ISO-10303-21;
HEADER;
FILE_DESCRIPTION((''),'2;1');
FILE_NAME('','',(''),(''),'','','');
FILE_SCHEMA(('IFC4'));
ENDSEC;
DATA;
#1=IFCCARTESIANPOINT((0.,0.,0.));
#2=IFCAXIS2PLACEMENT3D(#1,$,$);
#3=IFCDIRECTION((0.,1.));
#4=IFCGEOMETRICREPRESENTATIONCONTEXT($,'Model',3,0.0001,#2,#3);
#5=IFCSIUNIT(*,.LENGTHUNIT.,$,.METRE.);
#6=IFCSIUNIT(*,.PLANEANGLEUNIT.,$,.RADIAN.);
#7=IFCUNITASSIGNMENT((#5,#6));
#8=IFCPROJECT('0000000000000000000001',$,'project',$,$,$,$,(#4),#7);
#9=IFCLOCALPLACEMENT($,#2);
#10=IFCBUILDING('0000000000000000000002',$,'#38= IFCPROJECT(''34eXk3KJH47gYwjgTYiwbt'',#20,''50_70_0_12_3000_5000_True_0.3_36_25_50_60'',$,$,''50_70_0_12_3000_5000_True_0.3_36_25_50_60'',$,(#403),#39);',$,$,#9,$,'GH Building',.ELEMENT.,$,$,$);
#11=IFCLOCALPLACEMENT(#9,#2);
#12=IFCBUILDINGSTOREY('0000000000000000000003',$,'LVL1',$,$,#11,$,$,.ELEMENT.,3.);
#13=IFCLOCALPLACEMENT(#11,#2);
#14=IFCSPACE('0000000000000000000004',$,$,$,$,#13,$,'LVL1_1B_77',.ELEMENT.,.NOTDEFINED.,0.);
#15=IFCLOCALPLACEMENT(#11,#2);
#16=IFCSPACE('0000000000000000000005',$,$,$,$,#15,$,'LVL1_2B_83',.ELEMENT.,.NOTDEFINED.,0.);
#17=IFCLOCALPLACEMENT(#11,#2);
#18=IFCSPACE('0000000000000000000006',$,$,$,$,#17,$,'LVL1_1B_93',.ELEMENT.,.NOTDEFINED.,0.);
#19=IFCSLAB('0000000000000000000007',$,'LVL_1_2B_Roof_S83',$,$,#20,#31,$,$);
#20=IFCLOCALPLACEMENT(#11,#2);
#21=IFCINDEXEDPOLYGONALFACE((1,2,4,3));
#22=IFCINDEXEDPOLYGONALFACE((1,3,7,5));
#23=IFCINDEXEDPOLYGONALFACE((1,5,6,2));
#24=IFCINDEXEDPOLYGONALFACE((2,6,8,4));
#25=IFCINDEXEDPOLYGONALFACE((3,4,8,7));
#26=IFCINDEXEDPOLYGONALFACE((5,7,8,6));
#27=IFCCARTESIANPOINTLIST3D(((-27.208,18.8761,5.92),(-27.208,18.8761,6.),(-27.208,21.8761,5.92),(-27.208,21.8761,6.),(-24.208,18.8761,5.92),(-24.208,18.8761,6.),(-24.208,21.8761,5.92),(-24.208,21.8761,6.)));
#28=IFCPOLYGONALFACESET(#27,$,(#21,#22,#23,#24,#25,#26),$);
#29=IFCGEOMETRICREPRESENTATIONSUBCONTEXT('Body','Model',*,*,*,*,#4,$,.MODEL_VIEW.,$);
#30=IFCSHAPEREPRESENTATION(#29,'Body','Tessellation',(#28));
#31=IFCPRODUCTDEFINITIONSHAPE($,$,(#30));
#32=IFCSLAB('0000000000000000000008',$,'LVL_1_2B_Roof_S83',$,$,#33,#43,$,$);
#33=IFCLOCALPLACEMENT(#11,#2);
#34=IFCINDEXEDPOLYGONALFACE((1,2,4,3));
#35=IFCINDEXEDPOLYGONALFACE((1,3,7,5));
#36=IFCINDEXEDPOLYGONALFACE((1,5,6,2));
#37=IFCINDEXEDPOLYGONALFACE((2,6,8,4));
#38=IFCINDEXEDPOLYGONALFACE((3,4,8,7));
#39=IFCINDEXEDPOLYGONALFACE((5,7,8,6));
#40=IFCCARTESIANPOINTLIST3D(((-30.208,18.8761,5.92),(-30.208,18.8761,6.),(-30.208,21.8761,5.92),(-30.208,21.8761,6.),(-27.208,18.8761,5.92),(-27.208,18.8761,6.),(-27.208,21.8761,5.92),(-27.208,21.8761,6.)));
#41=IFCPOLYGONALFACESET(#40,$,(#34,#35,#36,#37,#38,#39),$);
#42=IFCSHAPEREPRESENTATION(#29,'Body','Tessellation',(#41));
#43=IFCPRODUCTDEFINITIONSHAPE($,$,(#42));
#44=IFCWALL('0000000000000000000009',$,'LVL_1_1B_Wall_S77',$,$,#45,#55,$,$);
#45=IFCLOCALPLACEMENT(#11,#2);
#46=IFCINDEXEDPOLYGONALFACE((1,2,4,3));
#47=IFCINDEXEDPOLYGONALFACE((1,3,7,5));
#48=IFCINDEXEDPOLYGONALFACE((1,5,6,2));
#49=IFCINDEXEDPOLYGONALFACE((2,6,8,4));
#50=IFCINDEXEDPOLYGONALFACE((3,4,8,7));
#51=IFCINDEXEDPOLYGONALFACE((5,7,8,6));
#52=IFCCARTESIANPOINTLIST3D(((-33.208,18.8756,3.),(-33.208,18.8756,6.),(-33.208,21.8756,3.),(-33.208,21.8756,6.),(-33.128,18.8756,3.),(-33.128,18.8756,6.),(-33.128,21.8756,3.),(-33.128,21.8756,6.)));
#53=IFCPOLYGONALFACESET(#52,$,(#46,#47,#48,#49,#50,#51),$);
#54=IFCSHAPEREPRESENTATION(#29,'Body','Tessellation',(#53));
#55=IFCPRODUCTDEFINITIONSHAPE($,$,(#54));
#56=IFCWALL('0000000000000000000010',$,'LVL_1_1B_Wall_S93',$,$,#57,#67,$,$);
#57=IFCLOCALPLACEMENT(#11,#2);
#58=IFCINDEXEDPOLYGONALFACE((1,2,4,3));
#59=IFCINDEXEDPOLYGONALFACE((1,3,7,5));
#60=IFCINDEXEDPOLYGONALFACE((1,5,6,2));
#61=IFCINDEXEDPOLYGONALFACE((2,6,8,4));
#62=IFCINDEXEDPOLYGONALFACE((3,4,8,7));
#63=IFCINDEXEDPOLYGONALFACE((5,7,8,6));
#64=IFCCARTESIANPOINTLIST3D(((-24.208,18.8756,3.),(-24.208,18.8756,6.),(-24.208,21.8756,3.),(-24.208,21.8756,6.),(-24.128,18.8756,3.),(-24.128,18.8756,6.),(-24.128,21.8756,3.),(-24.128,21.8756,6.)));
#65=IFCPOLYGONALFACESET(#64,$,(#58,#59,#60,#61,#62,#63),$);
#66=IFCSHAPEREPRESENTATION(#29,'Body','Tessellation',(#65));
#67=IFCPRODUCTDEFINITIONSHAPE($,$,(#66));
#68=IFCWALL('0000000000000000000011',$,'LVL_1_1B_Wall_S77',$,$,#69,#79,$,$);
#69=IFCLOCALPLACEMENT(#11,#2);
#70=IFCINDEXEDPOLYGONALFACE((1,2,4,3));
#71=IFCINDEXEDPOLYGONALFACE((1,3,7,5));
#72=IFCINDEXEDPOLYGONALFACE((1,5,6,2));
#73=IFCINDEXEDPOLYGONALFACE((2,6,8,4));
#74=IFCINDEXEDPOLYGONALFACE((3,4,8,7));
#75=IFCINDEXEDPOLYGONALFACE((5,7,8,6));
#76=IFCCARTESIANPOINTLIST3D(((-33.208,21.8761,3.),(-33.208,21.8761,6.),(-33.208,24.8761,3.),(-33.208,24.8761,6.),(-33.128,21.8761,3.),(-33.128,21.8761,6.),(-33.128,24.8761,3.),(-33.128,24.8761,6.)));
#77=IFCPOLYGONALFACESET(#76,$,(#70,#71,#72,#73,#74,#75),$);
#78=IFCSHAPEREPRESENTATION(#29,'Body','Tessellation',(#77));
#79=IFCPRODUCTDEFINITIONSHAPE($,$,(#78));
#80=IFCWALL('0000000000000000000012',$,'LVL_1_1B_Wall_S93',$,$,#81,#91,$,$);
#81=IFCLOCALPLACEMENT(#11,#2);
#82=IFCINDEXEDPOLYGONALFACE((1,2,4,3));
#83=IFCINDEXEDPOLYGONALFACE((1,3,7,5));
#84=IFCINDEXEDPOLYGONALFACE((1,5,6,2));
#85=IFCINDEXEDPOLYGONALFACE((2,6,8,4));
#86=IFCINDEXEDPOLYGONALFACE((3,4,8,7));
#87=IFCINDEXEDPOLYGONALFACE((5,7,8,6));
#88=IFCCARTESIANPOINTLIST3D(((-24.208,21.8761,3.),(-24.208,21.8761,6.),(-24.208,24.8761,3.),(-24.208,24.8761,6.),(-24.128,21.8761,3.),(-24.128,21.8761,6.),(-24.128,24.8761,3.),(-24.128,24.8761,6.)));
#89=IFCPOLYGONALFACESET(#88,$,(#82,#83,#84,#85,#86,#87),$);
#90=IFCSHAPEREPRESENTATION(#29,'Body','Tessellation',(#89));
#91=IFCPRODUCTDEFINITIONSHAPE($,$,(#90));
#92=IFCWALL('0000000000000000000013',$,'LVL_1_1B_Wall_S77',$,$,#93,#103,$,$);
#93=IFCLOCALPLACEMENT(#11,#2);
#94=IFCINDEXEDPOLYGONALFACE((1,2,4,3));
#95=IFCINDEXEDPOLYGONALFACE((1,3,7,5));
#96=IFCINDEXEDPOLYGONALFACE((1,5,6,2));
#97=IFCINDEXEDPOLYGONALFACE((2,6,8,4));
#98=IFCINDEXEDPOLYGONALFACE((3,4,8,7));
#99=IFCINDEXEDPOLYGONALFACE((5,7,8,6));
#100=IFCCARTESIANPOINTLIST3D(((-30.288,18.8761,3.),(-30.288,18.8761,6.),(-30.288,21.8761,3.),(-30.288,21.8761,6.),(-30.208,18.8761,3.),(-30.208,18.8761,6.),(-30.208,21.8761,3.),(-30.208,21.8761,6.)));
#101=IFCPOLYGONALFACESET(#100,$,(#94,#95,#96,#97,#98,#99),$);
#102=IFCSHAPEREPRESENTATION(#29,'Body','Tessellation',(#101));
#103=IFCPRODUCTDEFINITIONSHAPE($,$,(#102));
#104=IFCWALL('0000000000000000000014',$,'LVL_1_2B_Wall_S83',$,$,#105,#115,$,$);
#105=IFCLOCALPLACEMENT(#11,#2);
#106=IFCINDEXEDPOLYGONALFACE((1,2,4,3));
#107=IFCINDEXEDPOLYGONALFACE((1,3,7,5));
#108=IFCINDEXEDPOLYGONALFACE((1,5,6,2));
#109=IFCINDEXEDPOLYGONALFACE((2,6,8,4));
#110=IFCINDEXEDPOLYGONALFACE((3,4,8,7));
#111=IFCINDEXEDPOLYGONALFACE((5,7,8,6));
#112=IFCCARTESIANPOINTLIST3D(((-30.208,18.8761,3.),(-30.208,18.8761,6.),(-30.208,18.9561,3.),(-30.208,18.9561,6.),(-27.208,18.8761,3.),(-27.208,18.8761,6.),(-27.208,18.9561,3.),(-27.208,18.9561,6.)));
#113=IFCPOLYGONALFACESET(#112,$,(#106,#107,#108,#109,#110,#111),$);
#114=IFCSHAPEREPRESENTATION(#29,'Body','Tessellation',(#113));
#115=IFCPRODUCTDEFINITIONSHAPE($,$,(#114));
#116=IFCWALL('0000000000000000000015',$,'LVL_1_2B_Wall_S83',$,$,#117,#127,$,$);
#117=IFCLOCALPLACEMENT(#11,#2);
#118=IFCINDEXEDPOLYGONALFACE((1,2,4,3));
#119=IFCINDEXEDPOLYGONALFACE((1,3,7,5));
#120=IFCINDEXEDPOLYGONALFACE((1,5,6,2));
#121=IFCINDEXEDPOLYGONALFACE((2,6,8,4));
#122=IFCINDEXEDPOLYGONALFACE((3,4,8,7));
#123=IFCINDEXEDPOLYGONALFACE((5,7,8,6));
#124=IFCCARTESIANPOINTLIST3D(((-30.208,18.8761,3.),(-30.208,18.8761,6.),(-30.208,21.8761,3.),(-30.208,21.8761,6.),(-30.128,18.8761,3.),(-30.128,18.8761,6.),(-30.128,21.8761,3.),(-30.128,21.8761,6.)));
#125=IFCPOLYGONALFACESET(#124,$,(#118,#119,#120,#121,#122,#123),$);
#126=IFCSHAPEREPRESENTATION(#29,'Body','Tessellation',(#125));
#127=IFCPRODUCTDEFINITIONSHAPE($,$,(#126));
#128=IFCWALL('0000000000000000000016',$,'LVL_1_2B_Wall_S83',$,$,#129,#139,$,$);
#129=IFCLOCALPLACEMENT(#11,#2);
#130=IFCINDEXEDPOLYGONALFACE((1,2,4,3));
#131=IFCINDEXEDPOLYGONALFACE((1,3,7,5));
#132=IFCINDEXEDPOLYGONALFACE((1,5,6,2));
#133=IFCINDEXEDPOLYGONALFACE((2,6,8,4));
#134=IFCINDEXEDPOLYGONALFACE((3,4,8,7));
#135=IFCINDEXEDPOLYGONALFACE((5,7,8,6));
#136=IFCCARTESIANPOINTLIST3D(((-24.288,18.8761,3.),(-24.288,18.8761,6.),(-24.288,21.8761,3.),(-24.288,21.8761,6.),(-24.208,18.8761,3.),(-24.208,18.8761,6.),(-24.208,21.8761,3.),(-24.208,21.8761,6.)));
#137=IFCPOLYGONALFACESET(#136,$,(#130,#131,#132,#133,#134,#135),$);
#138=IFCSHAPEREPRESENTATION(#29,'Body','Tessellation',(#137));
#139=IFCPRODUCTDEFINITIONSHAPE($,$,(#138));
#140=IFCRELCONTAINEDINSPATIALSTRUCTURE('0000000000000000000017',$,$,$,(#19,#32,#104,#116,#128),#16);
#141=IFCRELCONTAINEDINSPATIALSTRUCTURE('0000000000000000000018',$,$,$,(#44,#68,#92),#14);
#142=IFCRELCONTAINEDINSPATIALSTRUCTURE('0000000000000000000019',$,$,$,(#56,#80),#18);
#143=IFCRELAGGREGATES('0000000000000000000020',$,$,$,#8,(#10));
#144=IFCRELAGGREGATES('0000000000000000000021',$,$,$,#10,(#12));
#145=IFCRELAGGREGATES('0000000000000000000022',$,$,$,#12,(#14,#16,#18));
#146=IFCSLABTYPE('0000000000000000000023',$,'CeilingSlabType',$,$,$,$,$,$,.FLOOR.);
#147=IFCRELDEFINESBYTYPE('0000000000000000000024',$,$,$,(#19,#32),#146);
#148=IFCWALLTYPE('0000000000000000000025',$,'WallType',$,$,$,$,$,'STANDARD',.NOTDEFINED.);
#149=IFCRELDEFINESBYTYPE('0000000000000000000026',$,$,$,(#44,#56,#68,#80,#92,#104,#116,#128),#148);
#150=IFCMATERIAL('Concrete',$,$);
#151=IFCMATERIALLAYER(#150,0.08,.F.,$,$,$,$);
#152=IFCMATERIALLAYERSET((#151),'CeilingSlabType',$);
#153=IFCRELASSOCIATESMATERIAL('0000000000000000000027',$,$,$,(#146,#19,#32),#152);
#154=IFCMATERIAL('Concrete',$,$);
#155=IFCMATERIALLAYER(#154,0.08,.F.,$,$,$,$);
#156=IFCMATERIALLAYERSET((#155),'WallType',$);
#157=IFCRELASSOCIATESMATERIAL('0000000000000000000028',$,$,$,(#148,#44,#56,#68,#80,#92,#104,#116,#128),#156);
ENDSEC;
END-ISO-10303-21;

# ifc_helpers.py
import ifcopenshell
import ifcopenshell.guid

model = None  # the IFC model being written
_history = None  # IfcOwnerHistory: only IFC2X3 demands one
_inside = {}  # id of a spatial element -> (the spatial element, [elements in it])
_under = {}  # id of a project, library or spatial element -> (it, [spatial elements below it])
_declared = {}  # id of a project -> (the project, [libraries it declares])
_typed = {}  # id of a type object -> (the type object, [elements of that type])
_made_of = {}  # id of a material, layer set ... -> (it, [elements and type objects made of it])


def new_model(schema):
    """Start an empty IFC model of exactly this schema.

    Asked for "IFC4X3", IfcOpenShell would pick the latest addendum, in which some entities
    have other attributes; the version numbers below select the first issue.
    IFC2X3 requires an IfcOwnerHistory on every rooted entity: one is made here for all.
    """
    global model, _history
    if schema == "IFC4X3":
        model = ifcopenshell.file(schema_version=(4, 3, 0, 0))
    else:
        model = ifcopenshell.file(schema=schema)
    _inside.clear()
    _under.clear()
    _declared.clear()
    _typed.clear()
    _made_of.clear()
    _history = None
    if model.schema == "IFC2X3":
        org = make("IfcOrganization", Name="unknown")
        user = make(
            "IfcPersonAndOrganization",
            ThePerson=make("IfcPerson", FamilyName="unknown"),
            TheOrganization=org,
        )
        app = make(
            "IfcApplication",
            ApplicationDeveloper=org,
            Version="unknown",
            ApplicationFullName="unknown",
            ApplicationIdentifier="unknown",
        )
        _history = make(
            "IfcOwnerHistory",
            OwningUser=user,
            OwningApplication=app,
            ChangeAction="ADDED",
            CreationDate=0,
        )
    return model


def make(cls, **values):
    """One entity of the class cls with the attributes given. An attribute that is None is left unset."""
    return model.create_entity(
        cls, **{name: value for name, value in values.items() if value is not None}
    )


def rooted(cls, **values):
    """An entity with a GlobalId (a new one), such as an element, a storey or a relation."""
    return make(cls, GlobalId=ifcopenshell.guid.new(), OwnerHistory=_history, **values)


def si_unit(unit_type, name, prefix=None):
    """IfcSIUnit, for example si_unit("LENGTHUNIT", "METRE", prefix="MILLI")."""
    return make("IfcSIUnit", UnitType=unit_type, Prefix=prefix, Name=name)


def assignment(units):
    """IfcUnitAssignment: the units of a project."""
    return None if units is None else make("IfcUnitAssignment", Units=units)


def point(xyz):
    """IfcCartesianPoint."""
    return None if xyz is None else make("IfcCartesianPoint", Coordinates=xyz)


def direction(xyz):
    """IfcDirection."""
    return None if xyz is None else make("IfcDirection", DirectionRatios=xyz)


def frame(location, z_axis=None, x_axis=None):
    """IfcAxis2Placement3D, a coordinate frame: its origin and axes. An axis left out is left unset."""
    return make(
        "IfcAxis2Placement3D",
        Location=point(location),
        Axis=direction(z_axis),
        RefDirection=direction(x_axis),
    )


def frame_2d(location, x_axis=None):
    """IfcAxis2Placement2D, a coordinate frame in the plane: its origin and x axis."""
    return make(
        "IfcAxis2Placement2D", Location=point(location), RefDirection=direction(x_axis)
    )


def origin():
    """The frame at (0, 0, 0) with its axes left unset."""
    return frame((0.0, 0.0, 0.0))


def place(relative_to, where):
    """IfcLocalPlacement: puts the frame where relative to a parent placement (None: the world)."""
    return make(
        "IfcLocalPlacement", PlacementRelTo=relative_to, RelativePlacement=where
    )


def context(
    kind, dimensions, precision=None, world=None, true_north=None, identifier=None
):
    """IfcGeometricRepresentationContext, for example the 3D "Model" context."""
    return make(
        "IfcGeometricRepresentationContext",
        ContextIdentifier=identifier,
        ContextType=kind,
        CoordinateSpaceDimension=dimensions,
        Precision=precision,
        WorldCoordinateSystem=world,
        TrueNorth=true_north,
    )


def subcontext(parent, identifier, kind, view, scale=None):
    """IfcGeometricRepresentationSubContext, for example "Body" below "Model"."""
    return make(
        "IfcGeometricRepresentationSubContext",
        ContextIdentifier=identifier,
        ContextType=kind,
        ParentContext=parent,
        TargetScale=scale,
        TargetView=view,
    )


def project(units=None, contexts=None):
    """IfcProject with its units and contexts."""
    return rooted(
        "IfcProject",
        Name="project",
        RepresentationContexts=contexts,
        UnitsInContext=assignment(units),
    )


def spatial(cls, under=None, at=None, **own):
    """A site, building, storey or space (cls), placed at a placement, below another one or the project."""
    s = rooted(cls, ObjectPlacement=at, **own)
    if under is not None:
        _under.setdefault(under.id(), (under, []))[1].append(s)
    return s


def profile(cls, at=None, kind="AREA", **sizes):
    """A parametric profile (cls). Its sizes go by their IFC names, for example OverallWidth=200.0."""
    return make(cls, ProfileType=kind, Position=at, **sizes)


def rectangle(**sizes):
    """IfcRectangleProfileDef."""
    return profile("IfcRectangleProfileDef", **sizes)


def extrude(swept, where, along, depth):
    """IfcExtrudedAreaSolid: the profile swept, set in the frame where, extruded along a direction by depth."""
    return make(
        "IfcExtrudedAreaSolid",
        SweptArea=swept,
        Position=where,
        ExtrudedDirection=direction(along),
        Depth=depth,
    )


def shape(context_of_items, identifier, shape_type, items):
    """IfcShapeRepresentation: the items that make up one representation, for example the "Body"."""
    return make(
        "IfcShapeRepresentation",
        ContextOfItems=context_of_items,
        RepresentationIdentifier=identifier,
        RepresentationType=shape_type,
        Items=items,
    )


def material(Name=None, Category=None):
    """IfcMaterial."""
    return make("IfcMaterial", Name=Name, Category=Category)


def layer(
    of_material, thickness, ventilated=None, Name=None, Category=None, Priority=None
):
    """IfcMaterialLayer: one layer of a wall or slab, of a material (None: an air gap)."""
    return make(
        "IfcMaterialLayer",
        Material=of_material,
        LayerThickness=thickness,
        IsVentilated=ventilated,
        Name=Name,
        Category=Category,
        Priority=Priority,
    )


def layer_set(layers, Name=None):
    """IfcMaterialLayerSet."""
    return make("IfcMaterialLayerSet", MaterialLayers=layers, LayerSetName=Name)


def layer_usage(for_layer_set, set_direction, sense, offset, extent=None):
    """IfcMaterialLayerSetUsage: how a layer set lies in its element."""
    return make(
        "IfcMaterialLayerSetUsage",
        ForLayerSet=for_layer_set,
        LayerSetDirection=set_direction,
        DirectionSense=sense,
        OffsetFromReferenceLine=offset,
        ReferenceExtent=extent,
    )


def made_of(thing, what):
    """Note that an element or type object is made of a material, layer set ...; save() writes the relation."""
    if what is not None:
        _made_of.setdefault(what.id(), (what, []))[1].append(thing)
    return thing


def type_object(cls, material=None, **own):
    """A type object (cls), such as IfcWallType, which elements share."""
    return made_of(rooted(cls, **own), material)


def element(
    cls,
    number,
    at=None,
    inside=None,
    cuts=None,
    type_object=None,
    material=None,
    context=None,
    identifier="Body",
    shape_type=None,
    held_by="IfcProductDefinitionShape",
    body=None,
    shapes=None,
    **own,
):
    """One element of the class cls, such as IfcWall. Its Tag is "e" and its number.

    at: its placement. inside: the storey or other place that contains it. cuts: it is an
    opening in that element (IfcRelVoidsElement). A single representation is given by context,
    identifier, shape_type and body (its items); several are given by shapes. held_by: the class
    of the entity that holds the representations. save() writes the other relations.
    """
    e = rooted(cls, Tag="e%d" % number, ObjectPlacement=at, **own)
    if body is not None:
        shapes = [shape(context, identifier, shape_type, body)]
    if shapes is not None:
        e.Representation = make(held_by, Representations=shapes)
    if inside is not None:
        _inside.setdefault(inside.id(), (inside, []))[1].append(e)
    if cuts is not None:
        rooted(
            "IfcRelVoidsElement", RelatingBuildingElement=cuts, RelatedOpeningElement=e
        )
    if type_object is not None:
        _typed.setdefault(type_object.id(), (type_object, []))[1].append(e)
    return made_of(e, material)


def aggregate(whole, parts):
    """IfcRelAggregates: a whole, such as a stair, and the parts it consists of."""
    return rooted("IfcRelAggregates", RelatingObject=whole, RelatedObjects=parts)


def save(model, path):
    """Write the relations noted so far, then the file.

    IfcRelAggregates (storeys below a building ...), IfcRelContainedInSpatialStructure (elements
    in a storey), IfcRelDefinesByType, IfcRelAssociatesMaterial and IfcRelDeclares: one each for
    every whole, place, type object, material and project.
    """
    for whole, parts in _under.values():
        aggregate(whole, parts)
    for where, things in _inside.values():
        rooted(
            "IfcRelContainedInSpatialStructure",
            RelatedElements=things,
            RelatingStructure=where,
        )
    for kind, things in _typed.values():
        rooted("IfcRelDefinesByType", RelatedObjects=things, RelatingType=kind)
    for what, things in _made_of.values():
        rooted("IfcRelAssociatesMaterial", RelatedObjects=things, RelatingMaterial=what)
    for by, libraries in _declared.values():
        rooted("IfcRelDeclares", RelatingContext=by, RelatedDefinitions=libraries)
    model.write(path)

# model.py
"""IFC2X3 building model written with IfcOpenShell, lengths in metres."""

from ifc_helpers import new_model, si_unit, direction, frame, frame_2d, origin, place, context, subcontext, project, spatial, rectangle, extrude, material, layer, layer_set, layer_usage, type_object, element, save


model = new_model("IFC2X3")

# Units and contexts
model_context = context("Model", 3, precision=0.0001, world=origin(), true_north=direction((0.0, 1.0)))
body_context = subcontext(model_context, "Body", "Model", "MODEL_VIEW")
ifc_project = project(units=[si_unit("LENGTHUNIT", "METRE"), si_unit("PLANEANGLEUNIT", "RADIAN")], contexts=[model_context])

# Building, storey
building_placement = place(None, origin())
building = spatial("IfcBuilding", under=ifc_project, at=building_placement, Name="#38= IFCPROJECT('34eXk3KJH47gYwjgTYiwbt',#20,'50_70_0_12_3000_5000_True_0.3_36_25_50_60',$,$,'50_70_0_12_3000_5000_True_0.3_36_25_50_60',$,(#403),#39);", LongName="GH Building", CompositionType="ELEMENT")
storey_placement = place(building_placement, origin())
storey = spatial("IfcBuildingStorey", under=building, at=storey_placement, Name="LVL1", CompositionType="ELEMENT", Elevation=3.0)

# Shared definitions
space_1_placement = place(storey_placement, origin())
space_1 = spatial("IfcSpace", under=storey, at=space_1_placement, LongName="LVL1_1B_77", CompositionType="ELEMENT", InteriorOrExteriorSpace="NOTDEFINED", ElevationWithFlooring=0.0)

# Shared definitions
ifc_material_1 = material(Name="Concrete")
ifc_layer_1 = layer(ifc_material_1, 0.08, ventilated=False)
ifc_layer_set_1 = layer_set([ifc_layer_1], Name="CeilingSlabType")
slab_type_1 = type_object("IfcSlabType", Name="CeilingSlabType", PredefinedType="FLOOR", material=ifc_layer_set_1)

# Shared definitions
space_2_placement = place(storey_placement, origin())
space_2 = spatial("IfcSpace", under=storey, at=space_2_placement, LongName="LVL1_2B_83", CompositionType="ELEMENT", InteriorOrExteriorSpace="NOTDEFINED", ElevationWithFlooring=0.0)

# Slabs
ifc_layer_usage_1 = layer_usage(ifc_layer_set_1, "AXIS3", "NEGATIVE", -0.08)
slab_1_placement = place(space_2_placement, frame((-24.208, 21.8761, 5.92), z_axis=(0.0, 0.0, 1.0), x_axis=(-1.0, 0.0, 0.0)))
element("IfcSlab", 1, at=slab_1_placement, inside=space_2, type_object=slab_type_1, material=ifc_layer_usage_1, Name="LVL_1_2B_Roof_S83", context=body_context, shape_type="SweptSolid", body=[
    extrude(rectangle(XDim=3.0, YDim=3.0, at=frame_2d((1.5, 1.5))), origin(), (0.0, 0.0, 1.0), 0.08),
])
ifc_layer_usage_2 = layer_usage(ifc_layer_set_1, "AXIS3", "NEGATIVE", -0.08)
slab_2_placement = place(space_2_placement, frame((-27.208, 21.8761, 5.92), z_axis=(0.0, 0.0, 1.0), x_axis=(-1.0, 0.0, 0.0)))
element("IfcSlab", 2, at=slab_2_placement, inside=space_2, type_object=slab_type_1, material=ifc_layer_usage_2, Name="LVL_1_2B_Roof_S83", context=body_context, shape_type="SweptSolid", body=[
    extrude(rectangle(XDim=3.0, YDim=3.0, at=frame_2d((1.5, 1.5))), origin(), (0.0, 0.0, 1.0), 0.08),
])

# Wall
ifc_material_2 = material(Name="Concrete")
ifc_layer_2 = layer(ifc_material_2, 0.08, ventilated=False)
ifc_layer_set_2 = layer_set([ifc_layer_2], Name="WallType")
ifc_layer_usage_3 = layer_usage(ifc_layer_set_2, "AXIS2", "NEGATIVE", 0.0)
wall_type = type_object("IfcWallType", Name="WallType", ElementType="STANDARD", PredefinedType="NOTDEFINED", material=ifc_layer_set_2)
wall_1_placement = place(space_1_placement, frame((-33.208, 18.8756, 3.0), z_axis=(0.0, 0.0, 1.0), x_axis=(0.0, 1.0, 0.0)))
element("IfcWall", 3, at=wall_1_placement, inside=space_1, type_object=wall_type, material=ifc_layer_usage_3, Name="LVL_1_1B_Wall_S77", context=body_context, shape_type="SweptSolid", body=[
    extrude(rectangle(XDim=3.0, YDim=0.08, at=frame_2d((1.5, -0.04))), origin(), (0.0, 0.0, 1.0), 3.0),
])

# Shared definitions
space_3_placement = place(storey_placement, origin())
space_3 = spatial("IfcSpace", under=storey, at=space_3_placement, LongName="LVL1_1B_93", CompositionType="ELEMENT", InteriorOrExteriorSpace="NOTDEFINED", ElevationWithFlooring=0.0)

# Walls
ifc_layer_usage_4 = layer_usage(ifc_layer_set_2, "AXIS2", "NEGATIVE", 0.0)
wall_2_placement = place(space_3_placement, frame((-24.208, 18.8756, 3.0), z_axis=(0.0, 0.0, 1.0), x_axis=(0.0, 1.0, 0.0)))
element("IfcWall", 4, at=wall_2_placement, inside=space_3, type_object=wall_type, material=ifc_layer_usage_4, Name="LVL_1_1B_Wall_S93", context=body_context, shape_type="SweptSolid", body=[
    extrude(rectangle(XDim=3.0, YDim=0.08, at=frame_2d((1.5, -0.04))), origin(), (0.0, 0.0, 1.0), 3.0),
])
ifc_layer_usage_5 = layer_usage(ifc_layer_set_2, "AXIS2", "NEGATIVE", 0.0)
wall_3_placement = place(space_1_placement, frame((-33.208, 21.8761, 3.0), z_axis=(0.0, 0.0, 1.0), x_axis=(0.0, 1.0, 0.0)))
element("IfcWall", 5, at=wall_3_placement, inside=space_1, type_object=wall_type, material=ifc_layer_usage_5, Name="LVL_1_1B_Wall_S77", context=body_context, shape_type="SweptSolid", body=[
    extrude(rectangle(XDim=3.0, YDim=0.08, at=frame_2d((1.5, -0.04))), origin(), (0.0, 0.0, 1.0), 3.0),
])
ifc_layer_usage_6 = layer_usage(ifc_layer_set_2, "AXIS2", "NEGATIVE", 0.0)
wall_4_placement = place(space_3_placement, frame((-24.208, 21.8761, 3.0), z_axis=(0.0, 0.0, 1.0), x_axis=(0.0, 1.0, 0.0)))
element("IfcWall", 6, at=wall_4_placement, inside=space_3, type_object=wall_type, material=ifc_layer_usage_6, Name="LVL_1_1B_Wall_S93", context=body_context, shape_type="SweptSolid", body=[
    extrude(rectangle(XDim=3.0, YDim=0.08, at=frame_2d((1.5, -0.04))), origin(), (0.0, 0.0, 1.0), 3.0),
])
ifc_layer_usage_7 = layer_usage(ifc_layer_set_2, "AXIS2", "NEGATIVE", 0.0)
wall_5_placement = place(space_1_placement, frame((-30.208, 21.8761, 3.0), z_axis=(0.0, 0.0, 1.0), x_axis=(0.0, -1.0, 0.0)))
element("IfcWall", 7, at=wall_5_placement, inside=space_1, type_object=wall_type, material=ifc_layer_usage_7, Name="LVL_1_1B_Wall_S77", context=body_context, shape_type="SweptSolid", body=[
    extrude(rectangle(XDim=3.0, YDim=0.08, at=frame_2d((1.5, -0.04))), origin(), (0.0, 0.0, 1.0), 3.0),
])

# Walls
ifc_layer_usage_8 = layer_usage(ifc_layer_set_2, "AXIS2", "NEGATIVE", 0.0)
wall_6_placement = place(space_2_placement, frame((-27.208, 18.8761, 3.0), z_axis=(0.0, 0.0, 1.0), x_axis=(-1.0, 0.0, 0.0)))
element("IfcWall", 8, at=wall_6_placement, inside=space_2, type_object=wall_type, material=ifc_layer_usage_8, Name="LVL_1_2B_Wall_S83", context=body_context, shape_type="SweptSolid", body=[
    extrude(rectangle(XDim=3.0, YDim=0.08, at=frame_2d((1.5, -0.04))), origin(), (0.0, 0.0, 1.0), 3.0),
])
ifc_layer_usage_9 = layer_usage(ifc_layer_set_2, "AXIS2", "NEGATIVE", 0.0)
wall_7_placement = place(space_2_placement, frame((-30.208, 18.8761, 3.0), z_axis=(0.0, 0.0, 1.0), x_axis=(0.0, 1.0, 0.0)))
element("IfcWall", 9, at=wall_7_placement, inside=space_2, type_object=wall_type, material=ifc_layer_usage_9, Name="LVL_1_2B_Wall_S83", context=body_context, shape_type="SweptSolid", body=[
    extrude(rectangle(XDim=3.0, YDim=0.08, at=frame_2d((1.5, -0.04))), origin(), (0.0, 0.0, 1.0), 3.0),
])
ifc_layer_usage_10 = layer_usage(ifc_layer_set_2, "AXIS2", "NEGATIVE", 0.0)
wall_8_placement = place(space_2_placement, frame((-24.208, 21.8761, 3.0), z_axis=(0.0, 0.0, 1.0), x_axis=(0.0, -1.0, 0.0)))
element("IfcWall", 10, at=wall_8_placement, inside=space_2, type_object=wall_type, material=ifc_layer_usage_10, Name="LVL_1_2B_Wall_S83", context=body_context, shape_type="SweptSolid", body=[
    extrude(rectangle(XDim=3.0, YDim=0.08, at=frame_2d((1.5, -0.04))), origin(), (0.0, 0.0, 1.0), 3.0),
])

save(model, "model.ifc")
